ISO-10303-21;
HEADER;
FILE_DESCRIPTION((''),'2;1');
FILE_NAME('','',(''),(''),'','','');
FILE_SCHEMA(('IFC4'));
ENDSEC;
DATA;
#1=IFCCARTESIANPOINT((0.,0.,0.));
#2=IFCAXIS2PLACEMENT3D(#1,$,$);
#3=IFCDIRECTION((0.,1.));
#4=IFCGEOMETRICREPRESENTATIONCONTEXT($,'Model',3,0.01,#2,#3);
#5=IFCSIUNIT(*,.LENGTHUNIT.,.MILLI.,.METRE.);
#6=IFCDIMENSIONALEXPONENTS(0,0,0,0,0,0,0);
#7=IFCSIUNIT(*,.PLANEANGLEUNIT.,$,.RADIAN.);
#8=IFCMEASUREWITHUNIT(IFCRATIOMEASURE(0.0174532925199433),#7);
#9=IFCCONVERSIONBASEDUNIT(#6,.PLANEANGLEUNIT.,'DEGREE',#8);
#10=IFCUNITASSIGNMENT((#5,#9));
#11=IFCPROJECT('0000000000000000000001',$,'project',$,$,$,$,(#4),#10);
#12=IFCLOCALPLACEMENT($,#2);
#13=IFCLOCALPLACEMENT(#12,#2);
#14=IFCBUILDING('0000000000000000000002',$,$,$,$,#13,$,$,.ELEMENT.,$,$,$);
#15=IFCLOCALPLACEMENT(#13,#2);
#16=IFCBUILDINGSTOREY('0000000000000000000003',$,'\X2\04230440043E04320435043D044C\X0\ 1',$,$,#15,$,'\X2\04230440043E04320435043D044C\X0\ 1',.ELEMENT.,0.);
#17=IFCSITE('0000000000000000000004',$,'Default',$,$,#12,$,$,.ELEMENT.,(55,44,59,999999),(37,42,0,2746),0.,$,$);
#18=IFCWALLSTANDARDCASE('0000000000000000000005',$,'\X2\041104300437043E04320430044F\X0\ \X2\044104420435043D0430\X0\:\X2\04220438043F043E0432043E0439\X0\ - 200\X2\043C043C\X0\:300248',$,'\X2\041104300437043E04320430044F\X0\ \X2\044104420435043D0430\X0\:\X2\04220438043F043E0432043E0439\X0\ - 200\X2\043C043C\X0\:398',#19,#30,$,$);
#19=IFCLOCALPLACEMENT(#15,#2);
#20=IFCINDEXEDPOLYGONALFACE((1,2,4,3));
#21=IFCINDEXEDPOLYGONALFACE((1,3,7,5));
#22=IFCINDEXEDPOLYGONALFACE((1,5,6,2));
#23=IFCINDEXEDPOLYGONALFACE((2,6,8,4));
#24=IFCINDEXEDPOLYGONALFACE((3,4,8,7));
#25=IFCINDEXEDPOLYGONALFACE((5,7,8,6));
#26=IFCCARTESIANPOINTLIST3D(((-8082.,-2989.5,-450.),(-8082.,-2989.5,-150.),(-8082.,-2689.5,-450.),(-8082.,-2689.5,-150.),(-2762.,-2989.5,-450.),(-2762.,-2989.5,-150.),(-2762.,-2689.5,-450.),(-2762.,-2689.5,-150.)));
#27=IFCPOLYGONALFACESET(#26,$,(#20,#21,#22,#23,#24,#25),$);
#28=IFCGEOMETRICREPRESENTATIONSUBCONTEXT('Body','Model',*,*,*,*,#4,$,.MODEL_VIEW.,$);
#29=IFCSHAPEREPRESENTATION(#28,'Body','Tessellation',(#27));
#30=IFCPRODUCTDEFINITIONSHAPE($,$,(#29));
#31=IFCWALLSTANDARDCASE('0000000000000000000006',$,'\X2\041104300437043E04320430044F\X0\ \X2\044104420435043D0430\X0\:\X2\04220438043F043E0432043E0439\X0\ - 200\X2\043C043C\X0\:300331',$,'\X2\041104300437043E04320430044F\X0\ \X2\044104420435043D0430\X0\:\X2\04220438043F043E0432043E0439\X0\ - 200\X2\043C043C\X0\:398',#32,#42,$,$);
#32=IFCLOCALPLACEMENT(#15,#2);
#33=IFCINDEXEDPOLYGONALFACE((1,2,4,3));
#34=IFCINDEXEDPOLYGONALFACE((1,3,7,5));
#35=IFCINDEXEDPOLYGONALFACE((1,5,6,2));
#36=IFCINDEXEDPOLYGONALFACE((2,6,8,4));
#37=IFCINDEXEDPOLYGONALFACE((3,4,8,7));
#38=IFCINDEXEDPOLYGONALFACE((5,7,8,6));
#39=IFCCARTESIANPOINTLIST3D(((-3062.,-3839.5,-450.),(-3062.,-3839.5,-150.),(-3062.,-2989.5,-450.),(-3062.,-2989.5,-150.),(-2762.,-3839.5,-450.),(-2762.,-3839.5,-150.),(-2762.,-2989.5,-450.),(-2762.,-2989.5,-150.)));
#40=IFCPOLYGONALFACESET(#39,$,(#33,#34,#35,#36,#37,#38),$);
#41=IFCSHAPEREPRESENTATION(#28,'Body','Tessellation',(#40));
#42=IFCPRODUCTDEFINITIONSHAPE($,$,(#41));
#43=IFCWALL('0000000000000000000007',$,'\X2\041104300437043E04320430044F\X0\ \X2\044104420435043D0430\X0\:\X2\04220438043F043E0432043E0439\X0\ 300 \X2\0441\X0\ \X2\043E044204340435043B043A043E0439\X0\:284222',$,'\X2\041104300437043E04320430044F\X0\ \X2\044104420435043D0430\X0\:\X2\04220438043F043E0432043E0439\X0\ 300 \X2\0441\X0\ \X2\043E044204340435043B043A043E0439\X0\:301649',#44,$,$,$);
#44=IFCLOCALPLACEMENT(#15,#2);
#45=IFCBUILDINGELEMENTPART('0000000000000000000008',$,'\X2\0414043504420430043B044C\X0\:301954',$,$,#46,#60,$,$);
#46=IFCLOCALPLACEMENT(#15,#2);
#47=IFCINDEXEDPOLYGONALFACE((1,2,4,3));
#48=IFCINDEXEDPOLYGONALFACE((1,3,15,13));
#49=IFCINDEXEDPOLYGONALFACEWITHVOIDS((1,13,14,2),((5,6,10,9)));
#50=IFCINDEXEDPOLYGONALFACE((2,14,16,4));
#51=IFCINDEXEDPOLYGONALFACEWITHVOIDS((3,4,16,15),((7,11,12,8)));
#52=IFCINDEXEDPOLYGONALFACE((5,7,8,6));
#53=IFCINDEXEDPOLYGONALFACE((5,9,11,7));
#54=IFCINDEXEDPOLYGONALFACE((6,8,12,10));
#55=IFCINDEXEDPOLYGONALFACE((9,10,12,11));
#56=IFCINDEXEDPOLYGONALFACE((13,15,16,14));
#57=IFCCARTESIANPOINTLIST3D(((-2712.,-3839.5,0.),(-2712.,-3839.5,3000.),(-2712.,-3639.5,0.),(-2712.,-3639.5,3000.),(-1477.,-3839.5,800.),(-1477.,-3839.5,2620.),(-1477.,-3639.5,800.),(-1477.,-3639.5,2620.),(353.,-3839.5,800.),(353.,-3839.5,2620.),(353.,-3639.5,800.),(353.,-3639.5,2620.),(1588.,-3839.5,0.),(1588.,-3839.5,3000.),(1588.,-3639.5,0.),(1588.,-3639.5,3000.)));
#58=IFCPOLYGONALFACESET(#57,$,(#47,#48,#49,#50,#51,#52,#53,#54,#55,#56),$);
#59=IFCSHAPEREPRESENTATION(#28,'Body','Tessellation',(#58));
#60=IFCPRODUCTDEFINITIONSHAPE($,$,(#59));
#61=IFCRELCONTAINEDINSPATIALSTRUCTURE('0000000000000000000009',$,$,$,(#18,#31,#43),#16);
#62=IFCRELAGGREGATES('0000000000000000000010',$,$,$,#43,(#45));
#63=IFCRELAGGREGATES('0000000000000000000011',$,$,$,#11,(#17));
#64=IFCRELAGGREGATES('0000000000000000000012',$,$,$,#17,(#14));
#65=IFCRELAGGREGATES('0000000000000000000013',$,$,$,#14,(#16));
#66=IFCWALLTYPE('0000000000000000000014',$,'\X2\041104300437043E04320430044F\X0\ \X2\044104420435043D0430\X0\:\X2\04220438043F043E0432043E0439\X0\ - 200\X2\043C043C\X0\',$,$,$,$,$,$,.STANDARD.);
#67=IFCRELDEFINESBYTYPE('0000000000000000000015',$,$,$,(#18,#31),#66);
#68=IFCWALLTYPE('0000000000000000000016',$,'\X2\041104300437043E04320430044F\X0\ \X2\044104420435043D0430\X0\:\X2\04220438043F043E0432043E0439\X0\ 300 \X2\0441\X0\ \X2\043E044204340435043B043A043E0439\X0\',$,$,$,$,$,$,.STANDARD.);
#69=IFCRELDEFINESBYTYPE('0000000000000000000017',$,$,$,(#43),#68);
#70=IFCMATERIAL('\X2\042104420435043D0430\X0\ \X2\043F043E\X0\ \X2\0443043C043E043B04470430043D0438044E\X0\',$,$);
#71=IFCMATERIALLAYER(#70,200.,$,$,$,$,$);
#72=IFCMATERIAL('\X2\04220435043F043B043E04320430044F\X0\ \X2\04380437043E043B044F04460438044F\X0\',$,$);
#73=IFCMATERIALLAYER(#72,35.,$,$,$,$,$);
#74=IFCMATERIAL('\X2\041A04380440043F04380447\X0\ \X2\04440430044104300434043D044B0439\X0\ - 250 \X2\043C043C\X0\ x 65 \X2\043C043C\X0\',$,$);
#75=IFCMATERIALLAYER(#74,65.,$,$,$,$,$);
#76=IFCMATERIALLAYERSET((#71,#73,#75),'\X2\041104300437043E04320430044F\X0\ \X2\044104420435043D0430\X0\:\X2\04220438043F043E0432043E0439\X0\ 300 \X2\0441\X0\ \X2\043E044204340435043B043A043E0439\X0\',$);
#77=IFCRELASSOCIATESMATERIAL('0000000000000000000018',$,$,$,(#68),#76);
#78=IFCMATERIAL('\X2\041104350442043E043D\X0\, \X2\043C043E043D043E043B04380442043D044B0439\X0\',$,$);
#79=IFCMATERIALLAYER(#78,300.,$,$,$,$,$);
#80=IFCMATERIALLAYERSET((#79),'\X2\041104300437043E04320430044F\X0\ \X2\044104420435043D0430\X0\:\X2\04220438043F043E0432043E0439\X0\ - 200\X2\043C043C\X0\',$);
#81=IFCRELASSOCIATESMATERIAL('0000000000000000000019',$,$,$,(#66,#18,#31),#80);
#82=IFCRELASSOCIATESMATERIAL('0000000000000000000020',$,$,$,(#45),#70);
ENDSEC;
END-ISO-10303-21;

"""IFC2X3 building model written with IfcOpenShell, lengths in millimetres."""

from ifc_helpers import new_model, entity, si_unit, converted_unit, direction, frame, frame_2d, origin, place, context, subcontext, project, spatial, rectangle, extrude, material, layer, layer_set, layer_usage, type_object, element, aggregate, save


model = new_model("IFC2X3")

# Units and contexts
model_context = context("Model", 3, precision=0.01, world=origin(), true_north=direction((0.0, 1.0)))
body_context = subcontext(model_context, "Body", "Model", "MODEL_VIEW")
ifc_project = project(units=[si_unit("LENGTHUNIT", "METRE", prefix="MILLI"), converted_unit("PLANEANGLEUNIT", "DEGREE", entity("IfcRatioMeasure", 0.0174532925199433), si_unit("PLANEANGLEUNIT", "RADIAN"), dimensions=[0, 0, 0, 0, 0, 0, 0])], contexts=[model_context])

# Site, building, storey
site_placement = place(None, origin())
site = spatial("IfcSite", under=ifc_project, at=site_placement, Name="Default", CompositionType="ELEMENT", RefLatitude=(55, 44, 59, 999999), RefLongitude=(37, 42, 0, 2746), RefElevation=0.0)
building_placement = place(site_placement, origin())
building = spatial("IfcBuilding", under=site, at=building_placement, CompositionType="ELEMENT")
storey_placement = place(building_placement, origin())
storey = spatial("IfcBuildingStorey", under=building, at=storey_placement, Name="Уровень 1", LongName="Уровень 1", CompositionType="ELEMENT", Elevation=0.0)

# Shared definitions
ifc_material_1 = material(Name="Стена по умолчанию")
ifc_layer_1 = layer(ifc_material_1, 200.0)
ifc_material_2 = material(Name="Тепловая изоляция")
ifc_layer_2 = layer(ifc_material_2, 35.0)
ifc_material_3 = material(Name="Кирпич фасадный - 250 мм x 65 мм")
ifc_layer_3 = layer(ifc_material_3, 65.0)
ifc_layer_set_1 = layer_set([ifc_layer_1, ifc_layer_2, ifc_layer_3], Name="Базовая стена:Типовой 300 с отделкой")
wall_type_1 = type_object("IfcWallType", Name="Базовая стена:Типовой 300 с отделкой", PredefinedType="STANDARD", material=ifc_layer_set_1)

# Walls
ifc_material_4 = material(Name="Бетон, монолитный")
ifc_layer_4 = layer(ifc_material_4, 300.0)
ifc_layer_set_2 = layer_set([ifc_layer_4], Name="Базовая стена:Типовой - 200мм")
wall_type_2 = type_object("IfcWallType", Name="Базовая стена:Типовой - 200мм", PredefinedType="STANDARD", material=ifc_layer_set_2)
ifc_layer_usage_1 = layer_usage(ifc_layer_set_2, "AXIS2", "NEGATIVE", 150.0)
wall_1_placement = place(storey_placement, frame((-8082.0, -2839.5, -450.0)))
element("IfcWallStandardCase", 1, at=wall_1_placement, inside=storey, type_object=wall_type_2, material=ifc_layer_usage_1, Name="Базовая стена:Типовой - 200мм:300248", ObjectType="Базовая стена:Типовой - 200мм:398", context=body_context, shape_type="SweptSolid", body=[
    extrude(rectangle(XDim=5320.0, YDim=300.0, at=frame_2d((2660.0, 0.0), x_axis=(-1.0, 0.0))), origin(), (0.0, 0.0, 1.0), 300.0),
])
ifc_layer_usage_2 = layer_usage(ifc_layer_set_2, "AXIS2", "NEGATIVE", 150.0)
wall_2_placement = place(storey_placement, frame((-2912.0, -2989.5, -450.0), z_axis=(0.0, 0.0, 1.0), x_axis=(0.0, -1.0, 0.0)))
element("IfcWallStandardCase", 2, at=wall_2_placement, inside=storey, type_object=wall_type_2, material=ifc_layer_usage_2, Name="Базовая стена:Типовой - 200мм:300331", ObjectType="Базовая стена:Типовой - 200мм:398", context=body_context, shape_type="SweptSolid", body=[
    extrude(rectangle(XDim=850.0, YDim=300.0, at=frame_2d((425.0, 0.0), x_axis=(-1.0, 0.0))), origin(), (0.0, 0.0, 1.0), 300.0),
])

# Wall, building element part, opening
wall_3_placement = place(storey_placement, frame((-2712.0, -3789.5, 0.0)))
wall_3 = element("IfcWall", 3, at=wall_3_placement, inside=storey, type_object=wall_type_1, Name="Базовая стена:Типовой 300 с отделкой:284222", ObjectType="Базовая стена:Типовой 300 с отделкой:301649")
building_element_part_1_placement = place(wall_3_placement, origin())
building_element_part_1 = element("IfcBuildingElementPart", 4, at=building_element_part_1_placement, material=ifc_material_1, Name="Деталь:301954", context=body_context, shape_type="SweptSolid", body=[
    extrude(rectangle(XDim=200.0, YDim=4300.0, at=frame_2d((0.0, 0.0), x_axis=(1.0, 0.0))), frame((2150.0, 50.0, 0.0), z_axis=(0.0, 0.0, 1.0), x_axis=(0.0, -1.0, 0.0)), (0.0, 0.0, 1.0), 3000.0),
])
opening_1_placement = place(wall_3_placement, origin())
opening_1 = element("IfcOpeningElement", 5, at=opening_1_placement, cuts=building_element_part_1, ObjectType="Opening", context=body_context, shape_type="SweptSolid", body=[
    extrude(rectangle(XDim=1820.0, YDim=1830.0, at=frame_2d((0.0, 0.0), x_axis=(1.0, 0.0))), frame((2150.0, -50.0, 1710.0), z_axis=(0.0, 1.0, 0.0), x_axis=(0.0, 0.0, 1.0)), (0.0, 0.0, 1.0), 200.0),
])
aggregate(wall_3, [building_element_part_1, opening_1])

save(model, "model.ifc")
